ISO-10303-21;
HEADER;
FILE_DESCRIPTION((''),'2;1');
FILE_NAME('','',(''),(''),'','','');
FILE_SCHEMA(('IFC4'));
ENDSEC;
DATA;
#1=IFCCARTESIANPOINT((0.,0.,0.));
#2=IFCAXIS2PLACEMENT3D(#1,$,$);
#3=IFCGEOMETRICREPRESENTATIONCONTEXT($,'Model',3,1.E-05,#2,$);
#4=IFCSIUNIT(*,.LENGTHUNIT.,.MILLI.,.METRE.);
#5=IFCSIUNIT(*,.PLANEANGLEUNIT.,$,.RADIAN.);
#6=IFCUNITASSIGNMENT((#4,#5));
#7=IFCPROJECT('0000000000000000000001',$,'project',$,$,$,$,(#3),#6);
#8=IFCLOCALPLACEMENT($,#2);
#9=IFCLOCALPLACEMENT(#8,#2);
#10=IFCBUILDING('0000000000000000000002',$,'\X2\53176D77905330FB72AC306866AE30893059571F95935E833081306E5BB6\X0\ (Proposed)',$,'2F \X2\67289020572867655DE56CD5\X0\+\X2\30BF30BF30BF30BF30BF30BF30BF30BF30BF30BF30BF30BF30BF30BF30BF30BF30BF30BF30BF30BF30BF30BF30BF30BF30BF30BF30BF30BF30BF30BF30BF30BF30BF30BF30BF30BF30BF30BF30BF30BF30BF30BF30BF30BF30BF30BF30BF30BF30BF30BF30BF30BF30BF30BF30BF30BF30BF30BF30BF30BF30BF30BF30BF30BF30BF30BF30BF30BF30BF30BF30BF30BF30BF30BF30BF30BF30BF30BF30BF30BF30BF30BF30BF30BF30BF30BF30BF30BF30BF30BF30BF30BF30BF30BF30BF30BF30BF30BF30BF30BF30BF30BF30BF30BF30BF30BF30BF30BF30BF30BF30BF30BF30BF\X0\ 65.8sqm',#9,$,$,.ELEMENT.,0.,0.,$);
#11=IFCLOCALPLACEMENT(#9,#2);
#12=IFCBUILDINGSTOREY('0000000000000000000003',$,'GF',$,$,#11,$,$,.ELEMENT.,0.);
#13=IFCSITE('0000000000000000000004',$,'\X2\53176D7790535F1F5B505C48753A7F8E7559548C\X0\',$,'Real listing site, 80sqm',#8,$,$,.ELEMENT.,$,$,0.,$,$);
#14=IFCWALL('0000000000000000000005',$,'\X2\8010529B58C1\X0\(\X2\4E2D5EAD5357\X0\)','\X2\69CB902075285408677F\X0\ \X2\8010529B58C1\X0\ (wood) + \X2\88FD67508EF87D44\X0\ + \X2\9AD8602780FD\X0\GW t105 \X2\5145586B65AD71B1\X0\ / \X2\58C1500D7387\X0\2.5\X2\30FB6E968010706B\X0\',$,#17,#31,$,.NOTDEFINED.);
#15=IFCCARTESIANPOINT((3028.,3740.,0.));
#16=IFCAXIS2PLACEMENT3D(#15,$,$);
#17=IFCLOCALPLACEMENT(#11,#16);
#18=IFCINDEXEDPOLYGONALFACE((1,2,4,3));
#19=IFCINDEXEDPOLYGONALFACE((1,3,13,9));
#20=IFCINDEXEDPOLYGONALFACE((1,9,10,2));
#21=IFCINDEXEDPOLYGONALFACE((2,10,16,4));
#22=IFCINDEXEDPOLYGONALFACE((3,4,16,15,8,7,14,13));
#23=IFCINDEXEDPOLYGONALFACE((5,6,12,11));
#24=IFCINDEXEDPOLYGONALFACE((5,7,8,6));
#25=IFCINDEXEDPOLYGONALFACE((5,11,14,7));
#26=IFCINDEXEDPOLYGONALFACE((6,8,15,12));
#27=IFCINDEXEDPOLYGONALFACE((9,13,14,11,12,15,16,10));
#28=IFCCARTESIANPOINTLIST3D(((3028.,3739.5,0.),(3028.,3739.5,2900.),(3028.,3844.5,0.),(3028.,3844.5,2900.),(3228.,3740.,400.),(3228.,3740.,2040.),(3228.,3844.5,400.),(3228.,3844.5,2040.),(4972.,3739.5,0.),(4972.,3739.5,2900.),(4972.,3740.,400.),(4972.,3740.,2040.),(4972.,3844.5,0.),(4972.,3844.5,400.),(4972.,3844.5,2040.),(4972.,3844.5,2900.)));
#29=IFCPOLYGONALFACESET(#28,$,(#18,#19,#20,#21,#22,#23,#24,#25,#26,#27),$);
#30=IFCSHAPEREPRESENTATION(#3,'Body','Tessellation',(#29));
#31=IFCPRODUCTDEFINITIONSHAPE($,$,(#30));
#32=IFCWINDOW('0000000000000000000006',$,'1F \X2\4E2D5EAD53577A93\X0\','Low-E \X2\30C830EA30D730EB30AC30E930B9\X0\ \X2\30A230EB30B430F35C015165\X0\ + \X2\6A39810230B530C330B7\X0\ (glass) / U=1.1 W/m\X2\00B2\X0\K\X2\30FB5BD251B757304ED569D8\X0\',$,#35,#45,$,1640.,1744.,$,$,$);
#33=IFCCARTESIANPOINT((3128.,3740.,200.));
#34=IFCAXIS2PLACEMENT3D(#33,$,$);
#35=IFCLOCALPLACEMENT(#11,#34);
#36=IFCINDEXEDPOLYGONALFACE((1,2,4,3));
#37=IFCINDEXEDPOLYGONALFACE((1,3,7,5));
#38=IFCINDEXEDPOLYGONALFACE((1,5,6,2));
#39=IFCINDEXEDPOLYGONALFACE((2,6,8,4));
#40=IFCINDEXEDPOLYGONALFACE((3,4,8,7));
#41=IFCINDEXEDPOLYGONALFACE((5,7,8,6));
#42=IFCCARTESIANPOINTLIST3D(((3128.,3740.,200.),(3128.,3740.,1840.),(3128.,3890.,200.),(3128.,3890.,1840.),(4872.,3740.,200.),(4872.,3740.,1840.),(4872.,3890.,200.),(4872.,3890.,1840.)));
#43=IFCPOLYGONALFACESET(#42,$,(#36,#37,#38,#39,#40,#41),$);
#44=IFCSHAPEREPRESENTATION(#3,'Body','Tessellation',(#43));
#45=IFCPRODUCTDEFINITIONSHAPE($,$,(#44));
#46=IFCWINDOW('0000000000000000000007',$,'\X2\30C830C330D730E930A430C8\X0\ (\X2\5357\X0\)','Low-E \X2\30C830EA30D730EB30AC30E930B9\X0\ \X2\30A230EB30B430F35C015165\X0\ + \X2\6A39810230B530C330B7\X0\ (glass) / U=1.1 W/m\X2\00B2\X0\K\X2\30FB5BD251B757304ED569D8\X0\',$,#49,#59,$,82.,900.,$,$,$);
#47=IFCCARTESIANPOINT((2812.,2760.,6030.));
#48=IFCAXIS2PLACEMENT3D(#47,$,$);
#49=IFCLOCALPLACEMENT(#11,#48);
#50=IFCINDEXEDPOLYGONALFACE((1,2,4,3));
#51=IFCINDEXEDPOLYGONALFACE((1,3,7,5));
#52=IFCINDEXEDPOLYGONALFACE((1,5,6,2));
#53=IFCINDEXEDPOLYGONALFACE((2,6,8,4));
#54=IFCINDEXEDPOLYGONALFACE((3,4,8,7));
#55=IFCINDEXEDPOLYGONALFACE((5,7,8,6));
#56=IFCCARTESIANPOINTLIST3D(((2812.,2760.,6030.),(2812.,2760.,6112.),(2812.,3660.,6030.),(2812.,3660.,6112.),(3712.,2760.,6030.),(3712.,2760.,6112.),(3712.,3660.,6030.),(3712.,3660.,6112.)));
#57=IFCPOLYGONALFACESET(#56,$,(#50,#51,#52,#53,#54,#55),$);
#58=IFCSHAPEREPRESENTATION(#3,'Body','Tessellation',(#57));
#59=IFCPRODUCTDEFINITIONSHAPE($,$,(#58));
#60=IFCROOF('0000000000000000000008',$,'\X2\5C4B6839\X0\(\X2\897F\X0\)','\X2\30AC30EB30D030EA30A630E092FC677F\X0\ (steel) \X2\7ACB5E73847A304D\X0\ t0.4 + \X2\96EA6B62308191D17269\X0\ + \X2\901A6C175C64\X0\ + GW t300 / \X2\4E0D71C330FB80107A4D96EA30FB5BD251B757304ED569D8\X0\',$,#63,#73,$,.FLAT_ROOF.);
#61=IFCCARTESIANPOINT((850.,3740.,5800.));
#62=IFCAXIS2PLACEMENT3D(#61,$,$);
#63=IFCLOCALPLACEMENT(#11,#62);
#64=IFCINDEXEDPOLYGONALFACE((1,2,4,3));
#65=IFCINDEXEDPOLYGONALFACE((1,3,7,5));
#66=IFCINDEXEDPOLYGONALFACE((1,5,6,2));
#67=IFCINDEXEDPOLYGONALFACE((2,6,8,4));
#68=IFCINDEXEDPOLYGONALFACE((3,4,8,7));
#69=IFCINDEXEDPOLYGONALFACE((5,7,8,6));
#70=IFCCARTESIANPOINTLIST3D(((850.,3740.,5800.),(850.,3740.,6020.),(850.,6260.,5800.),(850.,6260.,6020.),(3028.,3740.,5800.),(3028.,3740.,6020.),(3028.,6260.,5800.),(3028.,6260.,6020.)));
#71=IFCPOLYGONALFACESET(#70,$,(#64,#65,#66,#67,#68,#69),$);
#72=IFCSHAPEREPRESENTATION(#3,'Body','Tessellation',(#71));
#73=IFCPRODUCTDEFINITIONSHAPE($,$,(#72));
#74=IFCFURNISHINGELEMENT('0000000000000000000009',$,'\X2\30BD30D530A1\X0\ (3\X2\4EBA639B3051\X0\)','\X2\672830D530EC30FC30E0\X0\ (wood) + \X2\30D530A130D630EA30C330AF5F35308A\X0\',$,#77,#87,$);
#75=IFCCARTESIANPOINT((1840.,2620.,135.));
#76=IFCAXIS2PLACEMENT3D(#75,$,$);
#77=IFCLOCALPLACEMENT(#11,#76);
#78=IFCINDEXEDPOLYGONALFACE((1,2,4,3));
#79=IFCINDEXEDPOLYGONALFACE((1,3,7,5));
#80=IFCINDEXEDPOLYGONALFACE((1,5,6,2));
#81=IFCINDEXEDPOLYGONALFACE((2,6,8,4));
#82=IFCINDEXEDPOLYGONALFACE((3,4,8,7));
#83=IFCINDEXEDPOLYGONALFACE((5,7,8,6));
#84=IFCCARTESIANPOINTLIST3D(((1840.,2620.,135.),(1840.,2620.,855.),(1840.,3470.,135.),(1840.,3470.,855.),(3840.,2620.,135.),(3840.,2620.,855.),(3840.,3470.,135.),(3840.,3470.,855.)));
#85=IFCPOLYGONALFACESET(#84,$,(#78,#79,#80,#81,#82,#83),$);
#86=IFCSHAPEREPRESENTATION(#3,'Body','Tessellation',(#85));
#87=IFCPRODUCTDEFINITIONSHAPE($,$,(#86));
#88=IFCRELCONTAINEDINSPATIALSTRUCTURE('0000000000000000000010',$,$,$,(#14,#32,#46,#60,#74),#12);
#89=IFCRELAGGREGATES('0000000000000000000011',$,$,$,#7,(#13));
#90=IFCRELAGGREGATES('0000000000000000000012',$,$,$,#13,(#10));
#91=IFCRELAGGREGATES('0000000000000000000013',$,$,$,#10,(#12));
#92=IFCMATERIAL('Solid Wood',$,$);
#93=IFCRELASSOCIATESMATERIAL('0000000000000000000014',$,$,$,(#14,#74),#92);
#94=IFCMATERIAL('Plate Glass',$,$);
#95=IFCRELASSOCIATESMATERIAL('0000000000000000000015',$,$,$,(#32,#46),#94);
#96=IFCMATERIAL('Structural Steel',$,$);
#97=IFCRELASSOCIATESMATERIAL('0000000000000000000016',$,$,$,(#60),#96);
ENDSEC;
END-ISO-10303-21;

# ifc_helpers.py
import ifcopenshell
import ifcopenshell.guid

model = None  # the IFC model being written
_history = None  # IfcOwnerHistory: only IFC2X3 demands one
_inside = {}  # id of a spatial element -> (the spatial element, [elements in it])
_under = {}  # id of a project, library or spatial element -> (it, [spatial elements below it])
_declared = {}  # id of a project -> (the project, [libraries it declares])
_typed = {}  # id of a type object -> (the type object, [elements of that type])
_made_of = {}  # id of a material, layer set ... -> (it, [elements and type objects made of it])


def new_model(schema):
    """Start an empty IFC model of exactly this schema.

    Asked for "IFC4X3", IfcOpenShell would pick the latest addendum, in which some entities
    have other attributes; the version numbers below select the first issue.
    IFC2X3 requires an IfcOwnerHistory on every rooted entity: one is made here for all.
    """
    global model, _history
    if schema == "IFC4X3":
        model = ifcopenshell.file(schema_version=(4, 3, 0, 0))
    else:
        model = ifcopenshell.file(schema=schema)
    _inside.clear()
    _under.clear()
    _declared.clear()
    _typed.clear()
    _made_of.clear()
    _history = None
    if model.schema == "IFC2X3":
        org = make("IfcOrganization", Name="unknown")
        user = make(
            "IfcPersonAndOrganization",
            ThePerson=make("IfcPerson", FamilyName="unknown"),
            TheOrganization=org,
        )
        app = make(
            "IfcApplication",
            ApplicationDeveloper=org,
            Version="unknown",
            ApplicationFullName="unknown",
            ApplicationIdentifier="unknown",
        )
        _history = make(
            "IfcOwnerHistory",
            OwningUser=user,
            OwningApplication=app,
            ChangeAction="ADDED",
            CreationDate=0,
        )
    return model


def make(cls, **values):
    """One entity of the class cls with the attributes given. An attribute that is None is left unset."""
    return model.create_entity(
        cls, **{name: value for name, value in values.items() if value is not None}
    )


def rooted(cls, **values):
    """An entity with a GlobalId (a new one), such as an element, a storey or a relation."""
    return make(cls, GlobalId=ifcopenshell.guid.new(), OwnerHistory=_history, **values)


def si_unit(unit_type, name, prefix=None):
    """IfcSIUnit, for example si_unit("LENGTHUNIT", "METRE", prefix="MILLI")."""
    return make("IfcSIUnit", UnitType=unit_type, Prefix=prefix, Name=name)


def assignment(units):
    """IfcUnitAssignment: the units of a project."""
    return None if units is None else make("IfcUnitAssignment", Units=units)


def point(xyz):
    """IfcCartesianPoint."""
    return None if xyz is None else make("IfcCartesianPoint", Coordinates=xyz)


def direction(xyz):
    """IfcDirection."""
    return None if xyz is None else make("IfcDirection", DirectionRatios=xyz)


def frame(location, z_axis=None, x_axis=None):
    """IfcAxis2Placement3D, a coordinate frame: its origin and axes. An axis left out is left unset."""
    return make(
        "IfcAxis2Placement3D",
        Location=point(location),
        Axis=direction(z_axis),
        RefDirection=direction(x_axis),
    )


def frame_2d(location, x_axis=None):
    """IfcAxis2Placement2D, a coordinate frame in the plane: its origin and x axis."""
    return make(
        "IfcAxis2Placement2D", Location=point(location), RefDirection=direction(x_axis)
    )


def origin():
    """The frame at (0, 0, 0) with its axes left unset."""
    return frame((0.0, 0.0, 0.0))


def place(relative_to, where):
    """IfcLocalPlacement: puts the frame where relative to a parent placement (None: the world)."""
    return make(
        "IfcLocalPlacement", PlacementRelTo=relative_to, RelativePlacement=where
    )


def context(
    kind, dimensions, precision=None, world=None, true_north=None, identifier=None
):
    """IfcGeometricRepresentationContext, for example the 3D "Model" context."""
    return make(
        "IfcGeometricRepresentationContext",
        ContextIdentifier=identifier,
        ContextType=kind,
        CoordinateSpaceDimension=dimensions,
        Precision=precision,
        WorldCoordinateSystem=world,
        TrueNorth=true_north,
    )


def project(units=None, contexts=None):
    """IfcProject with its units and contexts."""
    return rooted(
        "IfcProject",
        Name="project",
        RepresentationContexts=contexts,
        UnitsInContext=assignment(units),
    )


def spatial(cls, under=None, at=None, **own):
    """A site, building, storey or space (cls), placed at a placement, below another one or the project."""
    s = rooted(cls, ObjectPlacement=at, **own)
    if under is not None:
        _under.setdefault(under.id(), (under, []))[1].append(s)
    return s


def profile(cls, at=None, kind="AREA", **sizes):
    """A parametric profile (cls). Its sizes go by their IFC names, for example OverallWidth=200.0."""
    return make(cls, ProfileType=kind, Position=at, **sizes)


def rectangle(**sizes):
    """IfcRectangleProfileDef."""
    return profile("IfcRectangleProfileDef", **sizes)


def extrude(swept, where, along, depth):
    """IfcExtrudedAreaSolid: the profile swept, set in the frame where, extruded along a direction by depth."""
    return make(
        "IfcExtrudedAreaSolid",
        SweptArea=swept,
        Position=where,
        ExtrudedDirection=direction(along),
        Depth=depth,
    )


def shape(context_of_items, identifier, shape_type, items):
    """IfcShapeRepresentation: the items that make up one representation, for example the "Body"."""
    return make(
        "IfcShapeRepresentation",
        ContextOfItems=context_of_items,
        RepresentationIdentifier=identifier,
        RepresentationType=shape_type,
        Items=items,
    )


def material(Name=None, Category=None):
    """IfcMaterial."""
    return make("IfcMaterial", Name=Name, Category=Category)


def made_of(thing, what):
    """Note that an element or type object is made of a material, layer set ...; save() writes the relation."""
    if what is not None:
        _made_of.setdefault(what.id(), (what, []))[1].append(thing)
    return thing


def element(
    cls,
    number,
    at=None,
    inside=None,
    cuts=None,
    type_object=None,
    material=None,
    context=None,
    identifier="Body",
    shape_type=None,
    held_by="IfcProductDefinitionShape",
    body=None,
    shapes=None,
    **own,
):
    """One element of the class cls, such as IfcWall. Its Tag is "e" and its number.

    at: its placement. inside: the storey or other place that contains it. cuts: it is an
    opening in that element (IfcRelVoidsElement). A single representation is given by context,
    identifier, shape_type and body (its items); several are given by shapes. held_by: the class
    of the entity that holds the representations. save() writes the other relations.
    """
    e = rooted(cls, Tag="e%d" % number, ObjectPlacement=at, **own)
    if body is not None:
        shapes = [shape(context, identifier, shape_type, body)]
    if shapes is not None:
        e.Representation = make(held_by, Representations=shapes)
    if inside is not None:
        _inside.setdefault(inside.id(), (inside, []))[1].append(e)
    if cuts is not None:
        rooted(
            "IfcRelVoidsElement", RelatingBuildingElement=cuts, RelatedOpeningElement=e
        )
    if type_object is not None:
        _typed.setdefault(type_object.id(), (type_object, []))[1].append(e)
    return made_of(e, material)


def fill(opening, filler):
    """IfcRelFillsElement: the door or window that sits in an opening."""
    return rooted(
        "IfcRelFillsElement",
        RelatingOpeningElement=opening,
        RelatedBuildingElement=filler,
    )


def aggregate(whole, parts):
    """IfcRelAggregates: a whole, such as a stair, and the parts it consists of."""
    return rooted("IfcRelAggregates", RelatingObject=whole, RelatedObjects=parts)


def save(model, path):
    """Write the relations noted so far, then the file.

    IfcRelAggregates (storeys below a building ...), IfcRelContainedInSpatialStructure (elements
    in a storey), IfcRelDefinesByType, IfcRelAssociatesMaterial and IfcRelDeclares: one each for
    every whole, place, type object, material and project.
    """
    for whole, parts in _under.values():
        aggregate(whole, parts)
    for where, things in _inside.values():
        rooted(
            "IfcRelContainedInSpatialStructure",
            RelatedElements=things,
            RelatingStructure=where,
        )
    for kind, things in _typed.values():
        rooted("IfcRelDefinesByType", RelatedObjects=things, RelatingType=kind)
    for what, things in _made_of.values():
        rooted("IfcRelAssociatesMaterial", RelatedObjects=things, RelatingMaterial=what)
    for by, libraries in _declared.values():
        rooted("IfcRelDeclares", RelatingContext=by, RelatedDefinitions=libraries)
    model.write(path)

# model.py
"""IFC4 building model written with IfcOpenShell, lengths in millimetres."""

from ifc_helpers import new_model, si_unit, frame, frame_2d, origin, place, context, project, spatial, rectangle, extrude, material, element, fill, save


model = new_model("IFC4")

# Units and contexts
model_context = context("Model", 3, precision=1e-05, world=origin())
ifc_project = project(units=[si_unit("LENGTHUNIT", "METRE", prefix="MILLI"), si_unit("PLANEANGLEUNIT", "RADIAN")], contexts=[model_context])

# Site, building, storey
site_placement = place(None, origin())
site = spatial("IfcSite", under=ifc_project, at=site_placement, Name="北海道弟子屈町美留和", ObjectType="Real listing site, 80sqm", CompositionType="ELEMENT", RefElevation=0.0)
building_placement = place(site_placement, origin())
building = spatial("IfcBuilding", under=site, at=building_placement, Name="北海道・犬と暮らす土間広めの家 (Proposed)", ObjectType="2F 木造在来工法+タタタタタタタタタタタタタタタタタタタタタタタタタタタタタタタタタタタタタタタタタタタタタタタタタタタタタタタタタタタタタタタタタタタタタタタタタタタタタタタタタタタタタタタタタタタタタタタタタタタタタタタタタタタタタタタタタ 65.8sqm", CompositionType="ELEMENT", ElevationOfRefHeight=0.0, ElevationOfTerrain=0.0)
storey_placement = place(building_placement, origin())
storey = spatial("IfcBuildingStorey", under=building, at=storey_placement, Name="GF", CompositionType="ELEMENT", Elevation=0.0)

# Shared definitions
ifc_material_1 = material(Name="Solid Wood")

# Wall, opening, window
wall_1_placement = place(storey_placement, frame((3028.0, 3740.0, 0.0)))
wall_1 = element("IfcWall", 1, at=wall_1_placement, inside=storey, material=ifc_material_1, Name="耐力壁(中庭南)", Description="構造用合板 耐力壁 (wood) + 製材軸組 + 高性能GW t105 充填断熱 / 壁倍率2.5・準耐火", PredefinedType="NOTDEFINED", context=model_context, shape_type="SweptSolid", body=[
    extrude(rectangle(XDim=1944.0, YDim=105.0, at=frame_2d((972.0, 52.0))), frame((3028.0, 3740.0, 0.0)), (0.0, 0.0, 1.0), 2900.0),
])
opening_placement = place(storey_placement, frame((3128.0, 3740.0, 200.0)))
opening = element("IfcOpeningElement", 2, at=opening_placement, cuts=wall_1, PredefinedType="NOTDEFINED", context=model_context, shape_type="SweptSolid", body=[
    extrude(rectangle(XDim=1744.0, YDim=150.0, at=frame_2d((872.0, 75.0))), frame((3128.0, 3740.0, 200.0)), (0.0, 0.0, 1.0), 1640.0),
])
ifc_material_2 = material(Name="Plate Glass")
window_1_placement = place(storey_placement, frame((3128.0, 3740.0, 200.0)))
window_1 = element("IfcWindow", 3, at=window_1_placement, inside=storey, material=ifc_material_2, Name="1F 中庭南窓", Description="Low-E トリプルガラス アルゴン封入 + 樹脂サッシ (glass) / U=1.1 W/m²K・寒冷地仕様", OverallHeight=1640.0, OverallWidth=1744.0, context=model_context, shape_type="SweptSolid", body=[
    extrude(rectangle(XDim=1744.0, YDim=150.0, at=frame_2d((872.0, 75.0))), frame((3128.0, 3740.0, 200.0)), (0.0, 0.0, 1.0), 1640.0),
])
fill(opening, window_1)

# Window
window_2_placement = place(storey_placement, frame((2812.0, 2760.0, 6030.0)))
element("IfcWindow", 4, at=window_2_placement, inside=storey, material=ifc_material_2, Name="トップライト (南)", Description="Low-E トリプルガラス アルゴン封入 + 樹脂サッシ (glass) / U=1.1 W/m²K・寒冷地仕様", OverallHeight=82.0, OverallWidth=900.0, context=model_context, shape_type="SweptSolid", body=[
    extrude(rectangle(XDim=900.0, YDim=900.0, at=frame_2d((450.0, 450.0))), frame((2812.0, 2760.0, 6030.0)), (0.0, 0.0, 1.0), 82.0),
])

# Roof
ifc_material_3 = material(Name="Structural Steel")
for number, where, name in (
    (5, (850.0, 3740.0, 5800.0), "屋根(西)"),
):
    element("IfcRoof", number, at=place(storey_placement, frame(where)), inside=storey, material=ifc_material_3, Name=name, Description="ガルバリウム鋼板 (steel) 立平葺き t0.4 + 雪止め金物 + 通気層 + GW t300 / 不燃・耐積雪・寒冷地仕様", PredefinedType="FLAT_ROOF", context=model_context, shape_type="SweptSolid", body=[
        extrude(rectangle(XDim=2178.0, YDim=2520.0, at=frame_2d((1089.0, 1260.0))), frame((850.0, 3740.0, 5800.0)), (0.0, 0.0, 1.0), 220.0),
    ])

# Furnishing element
furnishing_placement = place(storey_placement, frame((1840.0, 2620.0, 135.0)))
element("IfcFurnishingElement", 6, at=furnishing_placement, inside=storey, material=ifc_material_1, Name="ソファ (3人掛け)", Description="木フレーム (wood) + ファブリック張り", context=model_context, shape_type="SweptSolid", body=[
    extrude(rectangle(XDim=2000.0, YDim=850.0, at=frame_2d((1000.0, 425.0))), frame((1840.0, 2620.0, 135.0)), (0.0, 0.0, 1.0), 720.0),
])

save(model, "model.ifc")
